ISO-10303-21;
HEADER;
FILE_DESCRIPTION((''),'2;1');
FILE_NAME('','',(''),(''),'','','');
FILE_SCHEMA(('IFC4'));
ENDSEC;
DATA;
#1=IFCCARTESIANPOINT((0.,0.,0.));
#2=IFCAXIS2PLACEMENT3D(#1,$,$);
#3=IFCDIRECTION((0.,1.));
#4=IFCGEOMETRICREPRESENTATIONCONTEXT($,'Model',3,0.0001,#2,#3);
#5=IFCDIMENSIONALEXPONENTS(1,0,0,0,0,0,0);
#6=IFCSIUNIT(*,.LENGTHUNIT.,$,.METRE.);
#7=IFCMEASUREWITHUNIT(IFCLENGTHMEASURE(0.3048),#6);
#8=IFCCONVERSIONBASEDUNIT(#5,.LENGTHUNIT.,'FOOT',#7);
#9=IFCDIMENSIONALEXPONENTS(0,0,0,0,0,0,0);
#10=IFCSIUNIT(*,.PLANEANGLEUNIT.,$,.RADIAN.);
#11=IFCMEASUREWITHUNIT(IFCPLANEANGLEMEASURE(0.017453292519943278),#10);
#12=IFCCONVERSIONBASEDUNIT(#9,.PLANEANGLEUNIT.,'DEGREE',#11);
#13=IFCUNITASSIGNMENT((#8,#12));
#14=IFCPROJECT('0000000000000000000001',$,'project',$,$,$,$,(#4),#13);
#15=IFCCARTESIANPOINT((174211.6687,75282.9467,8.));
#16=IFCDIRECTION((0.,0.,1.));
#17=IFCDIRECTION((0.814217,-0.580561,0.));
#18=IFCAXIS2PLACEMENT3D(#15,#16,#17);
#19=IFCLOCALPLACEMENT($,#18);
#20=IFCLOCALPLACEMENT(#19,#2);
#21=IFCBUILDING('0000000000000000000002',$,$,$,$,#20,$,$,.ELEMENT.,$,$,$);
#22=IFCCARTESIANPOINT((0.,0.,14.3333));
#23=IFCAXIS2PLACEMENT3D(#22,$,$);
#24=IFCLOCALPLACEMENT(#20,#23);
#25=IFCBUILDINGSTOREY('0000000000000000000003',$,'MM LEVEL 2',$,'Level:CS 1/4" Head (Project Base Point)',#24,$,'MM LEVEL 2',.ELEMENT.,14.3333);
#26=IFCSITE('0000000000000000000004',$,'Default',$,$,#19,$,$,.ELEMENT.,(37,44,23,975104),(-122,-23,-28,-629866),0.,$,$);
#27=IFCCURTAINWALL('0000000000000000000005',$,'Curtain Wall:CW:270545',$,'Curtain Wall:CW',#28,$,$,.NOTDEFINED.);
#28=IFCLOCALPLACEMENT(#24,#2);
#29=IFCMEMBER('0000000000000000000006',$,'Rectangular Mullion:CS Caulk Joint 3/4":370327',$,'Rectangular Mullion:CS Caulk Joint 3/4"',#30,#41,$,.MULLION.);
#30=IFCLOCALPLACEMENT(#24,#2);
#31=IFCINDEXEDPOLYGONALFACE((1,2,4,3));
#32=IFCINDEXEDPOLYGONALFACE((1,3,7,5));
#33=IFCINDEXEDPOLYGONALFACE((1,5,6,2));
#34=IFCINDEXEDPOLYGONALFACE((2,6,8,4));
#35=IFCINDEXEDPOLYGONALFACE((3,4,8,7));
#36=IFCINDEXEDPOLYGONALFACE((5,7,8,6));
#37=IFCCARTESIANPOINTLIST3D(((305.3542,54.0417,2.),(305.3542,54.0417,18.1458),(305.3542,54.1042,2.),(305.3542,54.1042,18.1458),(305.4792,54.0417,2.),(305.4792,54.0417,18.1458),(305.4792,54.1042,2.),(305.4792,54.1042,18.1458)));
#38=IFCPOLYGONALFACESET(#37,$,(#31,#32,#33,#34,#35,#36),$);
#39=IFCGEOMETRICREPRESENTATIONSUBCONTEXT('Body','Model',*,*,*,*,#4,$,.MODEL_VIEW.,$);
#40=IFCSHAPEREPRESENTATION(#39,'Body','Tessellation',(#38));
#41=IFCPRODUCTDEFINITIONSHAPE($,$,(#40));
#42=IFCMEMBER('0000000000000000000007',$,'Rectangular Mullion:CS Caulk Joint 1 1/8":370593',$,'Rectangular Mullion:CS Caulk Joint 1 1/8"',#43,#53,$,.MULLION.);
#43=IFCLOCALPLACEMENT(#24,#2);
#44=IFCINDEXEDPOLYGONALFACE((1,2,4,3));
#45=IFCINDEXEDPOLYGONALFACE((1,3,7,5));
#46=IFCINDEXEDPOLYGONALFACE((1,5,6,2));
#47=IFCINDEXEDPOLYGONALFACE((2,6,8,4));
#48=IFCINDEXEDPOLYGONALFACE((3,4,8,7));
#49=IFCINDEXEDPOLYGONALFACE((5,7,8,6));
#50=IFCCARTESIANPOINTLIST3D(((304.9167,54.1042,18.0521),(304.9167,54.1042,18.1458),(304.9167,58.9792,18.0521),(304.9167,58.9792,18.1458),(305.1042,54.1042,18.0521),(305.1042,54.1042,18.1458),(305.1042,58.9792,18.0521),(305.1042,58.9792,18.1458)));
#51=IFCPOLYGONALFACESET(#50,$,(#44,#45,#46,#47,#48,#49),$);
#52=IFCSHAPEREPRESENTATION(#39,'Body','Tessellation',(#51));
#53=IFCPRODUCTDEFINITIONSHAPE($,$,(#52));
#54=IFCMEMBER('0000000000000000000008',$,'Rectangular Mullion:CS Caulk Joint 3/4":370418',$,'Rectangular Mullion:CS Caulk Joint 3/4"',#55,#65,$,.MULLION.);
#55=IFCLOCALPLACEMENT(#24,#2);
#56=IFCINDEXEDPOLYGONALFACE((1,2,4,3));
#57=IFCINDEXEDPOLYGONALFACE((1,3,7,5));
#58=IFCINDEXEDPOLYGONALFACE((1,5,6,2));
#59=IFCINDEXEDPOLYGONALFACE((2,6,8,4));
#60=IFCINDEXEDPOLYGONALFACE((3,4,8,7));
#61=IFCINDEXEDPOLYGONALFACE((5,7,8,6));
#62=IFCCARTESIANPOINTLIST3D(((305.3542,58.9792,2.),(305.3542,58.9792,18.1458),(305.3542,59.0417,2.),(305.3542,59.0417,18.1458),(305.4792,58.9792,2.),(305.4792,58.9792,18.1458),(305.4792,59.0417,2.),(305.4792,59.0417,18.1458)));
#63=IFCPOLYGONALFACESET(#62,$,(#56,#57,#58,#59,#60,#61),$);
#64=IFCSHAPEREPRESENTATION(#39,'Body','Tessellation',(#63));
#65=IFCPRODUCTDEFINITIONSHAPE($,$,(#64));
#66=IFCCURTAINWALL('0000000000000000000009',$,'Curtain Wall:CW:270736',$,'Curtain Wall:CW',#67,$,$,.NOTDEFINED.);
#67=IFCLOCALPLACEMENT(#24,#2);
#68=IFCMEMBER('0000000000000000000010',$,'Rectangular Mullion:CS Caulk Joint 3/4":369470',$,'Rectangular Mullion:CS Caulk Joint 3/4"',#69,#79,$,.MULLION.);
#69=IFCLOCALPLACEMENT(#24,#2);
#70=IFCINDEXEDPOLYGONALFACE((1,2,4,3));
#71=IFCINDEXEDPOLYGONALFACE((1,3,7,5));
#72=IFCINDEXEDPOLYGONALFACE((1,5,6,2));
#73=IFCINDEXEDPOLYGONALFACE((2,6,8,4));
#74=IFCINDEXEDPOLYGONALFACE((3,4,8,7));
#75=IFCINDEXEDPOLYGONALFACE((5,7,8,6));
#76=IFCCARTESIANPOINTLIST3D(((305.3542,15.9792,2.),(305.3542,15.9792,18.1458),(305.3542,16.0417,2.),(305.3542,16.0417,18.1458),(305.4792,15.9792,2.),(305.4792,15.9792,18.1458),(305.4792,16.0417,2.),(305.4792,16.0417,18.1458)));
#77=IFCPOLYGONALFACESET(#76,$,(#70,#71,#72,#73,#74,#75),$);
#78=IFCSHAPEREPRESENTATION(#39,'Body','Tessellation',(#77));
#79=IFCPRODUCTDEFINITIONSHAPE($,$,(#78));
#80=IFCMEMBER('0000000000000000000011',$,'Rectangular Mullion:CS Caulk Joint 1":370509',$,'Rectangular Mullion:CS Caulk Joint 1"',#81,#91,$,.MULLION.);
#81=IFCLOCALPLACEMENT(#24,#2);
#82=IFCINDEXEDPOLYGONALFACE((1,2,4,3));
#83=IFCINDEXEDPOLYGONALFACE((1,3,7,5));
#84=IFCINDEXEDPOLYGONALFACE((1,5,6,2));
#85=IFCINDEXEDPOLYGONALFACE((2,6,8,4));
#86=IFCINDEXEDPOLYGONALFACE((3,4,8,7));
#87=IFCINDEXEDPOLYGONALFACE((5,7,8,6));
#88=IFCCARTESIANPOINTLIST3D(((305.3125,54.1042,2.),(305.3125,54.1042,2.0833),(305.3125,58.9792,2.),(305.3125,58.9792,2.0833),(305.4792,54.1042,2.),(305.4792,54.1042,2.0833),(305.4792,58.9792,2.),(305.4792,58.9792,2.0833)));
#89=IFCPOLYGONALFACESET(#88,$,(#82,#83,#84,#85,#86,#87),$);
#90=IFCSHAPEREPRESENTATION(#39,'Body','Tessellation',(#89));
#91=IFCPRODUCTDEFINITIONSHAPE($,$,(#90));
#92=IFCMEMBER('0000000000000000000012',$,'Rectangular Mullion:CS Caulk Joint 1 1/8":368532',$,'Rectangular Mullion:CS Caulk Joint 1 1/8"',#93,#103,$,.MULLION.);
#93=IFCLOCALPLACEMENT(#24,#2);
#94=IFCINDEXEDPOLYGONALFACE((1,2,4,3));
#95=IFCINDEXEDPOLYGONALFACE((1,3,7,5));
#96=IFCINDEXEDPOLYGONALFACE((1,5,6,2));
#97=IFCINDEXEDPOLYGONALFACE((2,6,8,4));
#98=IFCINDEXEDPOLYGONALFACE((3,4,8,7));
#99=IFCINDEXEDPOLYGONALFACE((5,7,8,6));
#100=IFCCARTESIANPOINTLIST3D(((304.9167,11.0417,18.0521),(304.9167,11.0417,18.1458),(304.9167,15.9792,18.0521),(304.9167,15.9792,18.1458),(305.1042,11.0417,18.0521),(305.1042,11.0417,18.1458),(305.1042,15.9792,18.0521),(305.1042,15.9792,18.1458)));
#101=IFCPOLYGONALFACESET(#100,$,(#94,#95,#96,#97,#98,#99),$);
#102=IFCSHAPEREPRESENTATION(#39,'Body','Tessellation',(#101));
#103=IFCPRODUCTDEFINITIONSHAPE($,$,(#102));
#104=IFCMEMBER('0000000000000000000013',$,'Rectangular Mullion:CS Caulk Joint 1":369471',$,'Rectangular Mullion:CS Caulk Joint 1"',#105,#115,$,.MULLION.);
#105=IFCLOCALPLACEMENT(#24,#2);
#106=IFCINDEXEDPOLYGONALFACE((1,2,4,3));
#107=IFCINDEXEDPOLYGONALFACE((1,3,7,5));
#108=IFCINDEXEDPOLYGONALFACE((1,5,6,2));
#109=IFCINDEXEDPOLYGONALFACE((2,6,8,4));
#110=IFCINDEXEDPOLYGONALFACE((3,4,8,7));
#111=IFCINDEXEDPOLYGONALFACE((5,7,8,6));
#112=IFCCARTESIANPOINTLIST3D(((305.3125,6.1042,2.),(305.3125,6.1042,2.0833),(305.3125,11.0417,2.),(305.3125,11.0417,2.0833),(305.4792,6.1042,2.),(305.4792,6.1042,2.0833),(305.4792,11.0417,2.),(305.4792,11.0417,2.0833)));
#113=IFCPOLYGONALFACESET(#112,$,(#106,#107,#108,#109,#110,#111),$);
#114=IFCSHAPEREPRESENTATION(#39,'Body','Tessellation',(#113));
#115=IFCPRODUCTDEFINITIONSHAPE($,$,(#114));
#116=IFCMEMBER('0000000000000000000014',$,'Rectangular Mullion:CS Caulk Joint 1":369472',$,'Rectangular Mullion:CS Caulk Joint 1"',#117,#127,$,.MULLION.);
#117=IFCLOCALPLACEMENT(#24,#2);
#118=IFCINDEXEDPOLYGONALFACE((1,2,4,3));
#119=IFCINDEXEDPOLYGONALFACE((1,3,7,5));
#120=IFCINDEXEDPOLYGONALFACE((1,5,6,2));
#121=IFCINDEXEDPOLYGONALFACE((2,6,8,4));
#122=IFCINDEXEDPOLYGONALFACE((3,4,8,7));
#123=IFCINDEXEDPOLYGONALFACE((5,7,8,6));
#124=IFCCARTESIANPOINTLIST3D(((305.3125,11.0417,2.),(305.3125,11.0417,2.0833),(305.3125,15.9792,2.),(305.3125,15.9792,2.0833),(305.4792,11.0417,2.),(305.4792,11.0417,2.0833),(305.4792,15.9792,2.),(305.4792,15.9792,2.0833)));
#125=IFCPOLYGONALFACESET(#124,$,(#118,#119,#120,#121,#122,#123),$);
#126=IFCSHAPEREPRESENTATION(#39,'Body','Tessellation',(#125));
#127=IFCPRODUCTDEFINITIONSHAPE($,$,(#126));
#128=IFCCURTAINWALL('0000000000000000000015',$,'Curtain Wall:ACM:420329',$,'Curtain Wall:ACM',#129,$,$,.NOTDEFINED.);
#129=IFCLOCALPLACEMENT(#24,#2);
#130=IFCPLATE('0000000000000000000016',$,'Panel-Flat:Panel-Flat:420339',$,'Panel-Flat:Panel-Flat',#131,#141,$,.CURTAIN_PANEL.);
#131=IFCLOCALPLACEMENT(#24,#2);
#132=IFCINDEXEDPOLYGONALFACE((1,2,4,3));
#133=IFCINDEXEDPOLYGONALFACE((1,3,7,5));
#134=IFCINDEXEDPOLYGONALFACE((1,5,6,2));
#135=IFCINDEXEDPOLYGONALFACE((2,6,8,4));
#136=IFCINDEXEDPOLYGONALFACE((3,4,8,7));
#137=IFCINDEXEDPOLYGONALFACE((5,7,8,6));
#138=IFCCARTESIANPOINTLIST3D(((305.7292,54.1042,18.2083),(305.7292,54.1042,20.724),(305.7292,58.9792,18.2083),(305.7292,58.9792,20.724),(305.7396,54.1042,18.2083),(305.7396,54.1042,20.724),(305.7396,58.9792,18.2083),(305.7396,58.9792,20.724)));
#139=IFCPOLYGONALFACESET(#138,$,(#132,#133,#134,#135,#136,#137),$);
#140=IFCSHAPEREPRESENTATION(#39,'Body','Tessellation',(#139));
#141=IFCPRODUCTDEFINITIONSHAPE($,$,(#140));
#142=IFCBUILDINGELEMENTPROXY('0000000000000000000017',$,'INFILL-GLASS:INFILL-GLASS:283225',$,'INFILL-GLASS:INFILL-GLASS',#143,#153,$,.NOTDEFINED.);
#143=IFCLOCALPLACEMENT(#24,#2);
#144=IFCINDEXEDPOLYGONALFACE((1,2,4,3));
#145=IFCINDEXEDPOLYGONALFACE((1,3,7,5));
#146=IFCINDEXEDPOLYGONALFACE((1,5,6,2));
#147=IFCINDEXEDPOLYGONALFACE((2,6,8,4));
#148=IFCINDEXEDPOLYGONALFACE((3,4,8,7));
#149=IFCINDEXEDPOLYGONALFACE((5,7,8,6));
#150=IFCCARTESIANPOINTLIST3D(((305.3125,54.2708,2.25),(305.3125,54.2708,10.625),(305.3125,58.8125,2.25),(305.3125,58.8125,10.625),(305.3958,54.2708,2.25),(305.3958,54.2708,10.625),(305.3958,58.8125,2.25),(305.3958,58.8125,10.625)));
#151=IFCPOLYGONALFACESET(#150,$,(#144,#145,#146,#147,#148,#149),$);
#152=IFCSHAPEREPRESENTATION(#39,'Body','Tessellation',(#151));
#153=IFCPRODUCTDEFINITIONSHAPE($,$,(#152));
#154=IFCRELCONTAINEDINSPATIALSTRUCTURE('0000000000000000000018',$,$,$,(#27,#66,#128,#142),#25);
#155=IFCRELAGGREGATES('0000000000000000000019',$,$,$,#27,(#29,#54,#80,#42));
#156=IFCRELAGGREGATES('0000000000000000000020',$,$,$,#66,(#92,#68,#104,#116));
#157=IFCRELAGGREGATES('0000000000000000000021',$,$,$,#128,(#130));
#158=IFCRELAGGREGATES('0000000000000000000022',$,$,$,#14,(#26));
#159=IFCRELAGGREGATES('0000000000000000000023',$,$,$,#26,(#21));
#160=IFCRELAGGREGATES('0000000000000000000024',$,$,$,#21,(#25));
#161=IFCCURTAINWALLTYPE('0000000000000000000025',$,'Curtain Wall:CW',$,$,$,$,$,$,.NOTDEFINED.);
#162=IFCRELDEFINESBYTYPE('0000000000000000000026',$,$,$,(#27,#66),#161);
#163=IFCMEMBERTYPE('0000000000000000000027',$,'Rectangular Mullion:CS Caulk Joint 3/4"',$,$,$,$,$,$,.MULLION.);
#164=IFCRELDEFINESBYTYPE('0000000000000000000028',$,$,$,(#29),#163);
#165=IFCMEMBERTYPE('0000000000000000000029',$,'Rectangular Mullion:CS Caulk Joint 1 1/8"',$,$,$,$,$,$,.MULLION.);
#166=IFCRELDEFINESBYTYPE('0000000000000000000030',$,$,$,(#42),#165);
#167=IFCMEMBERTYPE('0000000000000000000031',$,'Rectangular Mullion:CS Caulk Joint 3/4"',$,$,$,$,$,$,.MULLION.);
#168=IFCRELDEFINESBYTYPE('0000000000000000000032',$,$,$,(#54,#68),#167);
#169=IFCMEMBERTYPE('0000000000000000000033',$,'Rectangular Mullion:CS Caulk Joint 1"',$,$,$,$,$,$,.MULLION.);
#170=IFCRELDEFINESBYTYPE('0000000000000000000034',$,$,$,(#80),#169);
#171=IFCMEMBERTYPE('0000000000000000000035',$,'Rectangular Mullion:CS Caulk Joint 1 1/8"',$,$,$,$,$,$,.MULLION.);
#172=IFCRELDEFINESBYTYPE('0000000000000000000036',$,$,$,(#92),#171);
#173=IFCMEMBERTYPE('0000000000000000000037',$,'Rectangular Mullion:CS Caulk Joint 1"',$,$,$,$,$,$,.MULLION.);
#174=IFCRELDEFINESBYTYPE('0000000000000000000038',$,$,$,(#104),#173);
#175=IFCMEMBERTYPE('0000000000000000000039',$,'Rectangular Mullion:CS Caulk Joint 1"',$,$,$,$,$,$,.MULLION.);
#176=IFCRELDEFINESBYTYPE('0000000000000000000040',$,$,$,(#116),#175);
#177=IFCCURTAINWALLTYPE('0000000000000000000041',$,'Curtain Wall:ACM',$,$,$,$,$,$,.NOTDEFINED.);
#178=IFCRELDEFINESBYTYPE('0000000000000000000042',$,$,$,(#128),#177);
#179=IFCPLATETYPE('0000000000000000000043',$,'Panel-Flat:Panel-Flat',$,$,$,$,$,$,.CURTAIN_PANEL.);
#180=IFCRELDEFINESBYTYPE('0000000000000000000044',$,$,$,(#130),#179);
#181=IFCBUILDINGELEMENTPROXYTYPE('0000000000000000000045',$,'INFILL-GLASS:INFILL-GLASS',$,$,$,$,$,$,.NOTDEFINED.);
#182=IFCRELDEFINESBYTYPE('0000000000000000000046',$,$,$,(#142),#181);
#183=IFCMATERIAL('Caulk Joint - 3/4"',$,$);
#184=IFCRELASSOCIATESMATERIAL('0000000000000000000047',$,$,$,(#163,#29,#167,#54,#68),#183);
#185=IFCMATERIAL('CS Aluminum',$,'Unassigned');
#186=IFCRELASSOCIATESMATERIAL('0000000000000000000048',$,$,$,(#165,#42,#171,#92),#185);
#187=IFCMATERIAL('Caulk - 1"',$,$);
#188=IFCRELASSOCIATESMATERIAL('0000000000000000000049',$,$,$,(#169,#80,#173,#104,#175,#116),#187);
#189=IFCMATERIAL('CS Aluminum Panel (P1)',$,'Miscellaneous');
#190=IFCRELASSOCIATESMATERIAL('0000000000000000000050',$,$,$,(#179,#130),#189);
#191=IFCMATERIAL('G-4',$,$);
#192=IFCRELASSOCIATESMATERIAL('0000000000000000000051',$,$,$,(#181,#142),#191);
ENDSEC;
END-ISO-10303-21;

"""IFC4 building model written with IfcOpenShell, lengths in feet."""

from ifc_helpers import new_model, entity, si_unit, converted_unit, direction, frame, origin, place, context, subcontext, project, spatial, indexed_curve, outline, extrude, source, transform, mapped, material, type_object, type_shapes, element, aggregate, save


model = new_model("IFC4")

# Units and contexts
model_context = context("Model", 3, precision=0.0001, world=origin(), true_north=direction((0.0, 1.0)))
body_context = subcontext(model_context, "Body", "Model", "MODEL_VIEW")
ifc_project = project(units=[converted_unit("LENGTHUNIT", "FOOT", entity("IfcLengthMeasure", 0.3048), si_unit("LENGTHUNIT", "METRE"), dimensions=[1, 0, 0, 0, 0, 0, 0]), converted_unit("PLANEANGLEUNIT", "DEGREE", entity("IfcPlaneAngleMeasure", 0.017453292519943278), si_unit("PLANEANGLEUNIT", "RADIAN"), dimensions=[0, 0, 0, 0, 0, 0, 0])], contexts=[model_context])

# Site, building, storey
site_placement = place(None, frame((174211.6687, 75282.9467, 8.0), z_axis=(0.0, 0.0, 1.0), x_axis=(0.814217, -0.580561, 0.0)))
site = spatial("IfcSite", under=ifc_project, at=site_placement, Name="Default", CompositionType="ELEMENT", RefLatitude=(37, 44, 23, 975104), RefLongitude=(-122, -23, -28, -629866), RefElevation=0.0)
building_placement = place(site_placement, origin())
building = spatial("IfcBuilding", under=site, at=building_placement, CompositionType="ELEMENT")
storey_placement = place(building_placement, frame((0.0, 0.0, 14.3333)))
storey = spatial("IfcBuildingStorey", under=building, at=storey_placement, Name="MM LEVEL 2", ObjectType="Level:CS 1/4\" Head (Project Base Point)", LongName="MM LEVEL 2", CompositionType="ELEMENT", Elevation=14.3333)

# Curtain wall, members
curtain_wall_type_1 = type_object("IfcCurtainWallType", Name="Curtain Wall:CW", PredefinedType="NOTDEFINED")
curtain_wall_1_placement = place(storey_placement, frame((0.0, 0.0, -14.3333)))
curtain_wall_1 = element("IfcCurtainWall", 1, at=curtain_wall_1_placement, inside=storey, type_object=curtain_wall_type_1, Name="Curtain Wall:CW:270545", ObjectType="Curtain Wall:CW", PredefinedType="NOTDEFINED")
ifc_material_1 = material(Name="Caulk Joint - 3/4\"")
member_type_1 = type_object("IfcMemberType", Name="Rectangular Mullion:CS Caulk Joint 3/4\"", PredefinedType="MULLION", material=ifc_material_1)
shared_shape_1 = source(origin(), body_context, "Body", "SweptSolid", [
    extrude(outline(indexed_curve([(-0.0625, -0.0312), (0.0625, -0.0312), (0.0625, 0.0312), (-0.0625, 0.0312), (-0.0625, -0.0312)], self_intersect=False)), frame((-0.0312, 0.0625, -16.1458), z_axis=(0.0, 0.0, 1.0), x_axis=(0.0, -1.0, 0.0)), (0.0, 0.0, 1.0), 16.1458),
])
type_shapes(member_type_1, [shared_shape_1])
member_1_placement = place(curtain_wall_1_placement, frame((305.4792, 54.0417, 16.3333), z_axis=(0.0, 0.0, -1.0), x_axis=(0.0, -1.0, 0.0)))
member_1 = element("IfcMember", 2, at=member_1_placement, type_object=member_type_1, material=ifc_material_1, Name="Rectangular Mullion:CS Caulk Joint 3/4\":370327", ObjectType="Rectangular Mullion:CS Caulk Joint 3/4\"", PredefinedType="MULLION", context=body_context, shape_type="MappedRepresentation", body=[
    mapped(shared_shape_1, transform((0.0, 0.0, 0.0), scale=1.0)),
])
ifc_material_2 = material(Name="CS Aluminum", Category="Unassigned")
member_type_2 = type_object("IfcMemberType", Name="Rectangular Mullion:CS Caulk Joint 1 1/8\"", PredefinedType="MULLION", material=ifc_material_2)
shared_shape_2 = source(origin(), body_context, "Body", "SweptSolid", [
    extrude(outline(indexed_curve([(-0.0937, -0.0469), (0.0938, -0.0469), (0.0938, 0.0469), (-0.0937, 0.0469), (-0.0937, -0.0469)], self_intersect=False)), frame((-0.0469, 0.4688, -4.875), z_axis=(0.0, 0.0, 1.0), x_axis=(0.0, -1.0, 0.0)), (0.0, 0.0, 1.0), 4.875),
])
type_shapes(member_type_2, [shared_shape_2])
member_2_placement = place(curtain_wall_1_placement, frame((305.4792, 54.1042, 32.4792), z_axis=(0.0, -1.0, 0.0), x_axis=(0.0, 0.0, 1.0)))
member_2 = element("IfcMember", 3, at=member_2_placement, type_object=member_type_2, material=ifc_material_2, Name="Rectangular Mullion:CS Caulk Joint 1 1/8\":370593", ObjectType="Rectangular Mullion:CS Caulk Joint 1 1/8\"", PredefinedType="MULLION", context=body_context, shape_type="MappedRepresentation", body=[
    mapped(shared_shape_2, transform((0.0, 0.0, 0.0), scale=1.0)),
])
member_type_3 = type_object("IfcMemberType", Name="Rectangular Mullion:CS Caulk Joint 3/4\"", PredefinedType="MULLION", material=ifc_material_1)
shared_shape_3 = source(origin(), body_context, "Body", "SweptSolid", [
    extrude(outline(indexed_curve([(-0.0312, -0.0625), (0.0312, -0.0625), (0.0312, 0.0625), (-0.0312, 0.0625), (-0.0312, -0.0625)], self_intersect=False)), frame((-0.0312, 0.0625, -16.1458), z_axis=(0.0, 0.0, 1.0), x_axis=(-1.0, 0.0, 0.0)), (0.0, 0.0, 1.0), 16.1458),
])
type_shapes(member_type_3, [shared_shape_3])
member_3_placement = place(curtain_wall_1_placement, frame((305.4792, 59.0417, 32.4792), z_axis=(0.0, 0.0, 1.0), x_axis=(0.0, 1.0, 0.0)))
member_3 = element("IfcMember", 4, at=member_3_placement, type_object=member_type_3, material=ifc_material_1, Name="Rectangular Mullion:CS Caulk Joint 3/4\":370418", ObjectType="Rectangular Mullion:CS Caulk Joint 3/4\"", PredefinedType="MULLION", context=body_context, shape_type="MappedRepresentation", body=[
    mapped(shared_shape_3, transform((0.0, 0.0, 0.0), scale=1.0)),
])

# Curtain wall, member
curtain_wall_2_placement = place(storey_placement, frame((0.0, 0.0, -14.3333)))
curtain_wall_2 = element("IfcCurtainWall", 5, at=curtain_wall_2_placement, inside=storey, type_object=curtain_wall_type_1, Name="Curtain Wall:CW:270736", ObjectType="Curtain Wall:CW", PredefinedType="NOTDEFINED")
member_4_placement = place(curtain_wall_2_placement, frame((305.4792, 16.0417, 32.4792), z_axis=(0.0, 0.0, 1.0), x_axis=(0.0, 1.0, 0.0)))
member_4 = element("IfcMember", 6, at=member_4_placement, type_object=member_type_3, material=ifc_material_1, Name="Rectangular Mullion:CS Caulk Joint 3/4\":369470", ObjectType="Rectangular Mullion:CS Caulk Joint 3/4\"", PredefinedType="MULLION", context=body_context, shape_type="MappedRepresentation", body=[
    mapped(shared_shape_3, transform((0.0, 0.0, 0.0), scale=1.0)),
])

# Members
ifc_material_3 = material(Name="Caulk - 1\"")
member_type_4 = type_object("IfcMemberType", Name="Rectangular Mullion:CS Caulk Joint 1\"", PredefinedType="MULLION", material=ifc_material_3)
shared_shape_4 = source(origin(), body_context, "Body", "SweptSolid", [
    extrude(outline(indexed_curve([(-0.0417, -0.0833), (0.0417, -0.0833), (0.0417, 0.0833), (-0.0417, 0.0833), (-0.0417, -0.0833)], self_intersect=False)), frame((-0.0417, 0.0833, -4.875), z_axis=(0.0, 0.0, 1.0), x_axis=(-1.0, 0.0, 0.0)), (0.0, 0.0, 1.0), 4.875),
])
type_shapes(member_type_4, [shared_shape_4])
member_5_placement = place(curtain_wall_1_placement, frame((305.4792, 58.9792, 16.3333), z_axis=(0.0, 1.0, 0.0), x_axis=(0.0, 0.0, -1.0)))
member_5 = element("IfcMember", 7, at=member_5_placement, type_object=member_type_4, material=ifc_material_3, Name="Rectangular Mullion:CS Caulk Joint 1\":370509", ObjectType="Rectangular Mullion:CS Caulk Joint 1\"", PredefinedType="MULLION", context=body_context, shape_type="MappedRepresentation", body=[
    mapped(shared_shape_4, transform((0.0, 0.0, 0.0), scale=1.0)),
])
aggregate(curtain_wall_1, [member_1, member_3, member_5, member_2])
member_type_5 = type_object("IfcMemberType", Name="Rectangular Mullion:CS Caulk Joint 1 1/8\"", PredefinedType="MULLION", material=ifc_material_2)
shared_shape_5 = source(origin(), body_context, "Body", "SweptSolid", [
    extrude(outline(indexed_curve([(-0.0937, -0.0469), (0.0938, -0.0469), (0.0938, 0.0469), (-0.0937, 0.0469), (-0.0937, -0.0469)], self_intersect=False)), frame((-0.0469, 0.4688, -4.9375), z_axis=(0.0, 0.0, 1.0), x_axis=(0.0, -1.0, 0.0)), (0.0, 0.0, 1.0), 4.9375),
])
type_shapes(member_type_5, [shared_shape_5])
member_6_placement = place(curtain_wall_2_placement, frame((305.4792, 11.0417, 32.4792), z_axis=(0.0, -1.0, 0.0), x_axis=(0.0, 0.0, 1.0)))
member_6 = element("IfcMember", 8, at=member_6_placement, type_object=member_type_5, material=ifc_material_2, Name="Rectangular Mullion:CS Caulk Joint 1 1/8\":368532", ObjectType="Rectangular Mullion:CS Caulk Joint 1 1/8\"", PredefinedType="MULLION", context=body_context, shape_type="MappedRepresentation", body=[
    mapped(shared_shape_5, transform((0.0, 0.0, 0.0), scale=1.0)),
])
member_type_6 = type_object("IfcMemberType", Name="Rectangular Mullion:CS Caulk Joint 1\"", PredefinedType="MULLION", material=ifc_material_3)
shared_shape_6 = source(origin(), body_context, "Body", "SweptSolid", [
    extrude(outline(indexed_curve([(-0.0417, -0.0833), (0.0417, -0.0833), (0.0417, 0.0833), (-0.0417, 0.0833), (-0.0417, -0.0833)], self_intersect=False)), frame((-0.0417, 0.0833, -4.9375), z_axis=(0.0, 0.0, 1.0), x_axis=(-1.0, 0.0, 0.0)), (0.0, 0.0, 1.0), 4.9375),
])
type_shapes(member_type_6, [shared_shape_6])
member_7_placement = place(curtain_wall_2_placement, frame((305.4792, 11.0417, 16.3333), z_axis=(0.0, 1.0, 0.0), x_axis=(0.0, 0.0, -1.0)))
member_7 = element("IfcMember", 9, at=member_7_placement, type_object=member_type_6, material=ifc_material_3, Name="Rectangular Mullion:CS Caulk Joint 1\":369471", ObjectType="Rectangular Mullion:CS Caulk Joint 1\"", PredefinedType="MULLION", context=body_context, shape_type="MappedRepresentation", body=[
    mapped(shared_shape_6, transform((0.0, 0.0, 0.0), scale=1.0)),
])
member_type_7 = type_object("IfcMemberType", Name="Rectangular Mullion:CS Caulk Joint 1\"", PredefinedType="MULLION", material=ifc_material_3)
shared_shape_7 = source(origin(), body_context, "Body", "SweptSolid", [
    extrude(outline(indexed_curve([(-0.0417, -0.0833), (0.0417, -0.0833), (0.0417, 0.0833), (-0.0417, 0.0833), (-0.0417, -0.0833)], self_intersect=False)), frame((-0.0417, 0.0833, -4.9375), z_axis=(0.0, 0.0, 1.0), x_axis=(-1.0, 0.0, 0.0)), (0.0, 0.0, 1.0), 4.9375),
])
type_shapes(member_type_7, [shared_shape_7])
member_8_placement = place(curtain_wall_2_placement, frame((305.4792, 15.9792, 16.3333), z_axis=(0.0, 1.0, 0.0), x_axis=(0.0, 0.0, -1.0)))
member_8 = element("IfcMember", 10, at=member_8_placement, type_object=member_type_7, material=ifc_material_3, Name="Rectangular Mullion:CS Caulk Joint 1\":369472", ObjectType="Rectangular Mullion:CS Caulk Joint 1\"", PredefinedType="MULLION", context=body_context, shape_type="MappedRepresentation", body=[
    mapped(shared_shape_7, transform((0.0, 0.0, 0.0), scale=1.0)),
])
aggregate(curtain_wall_2, [member_6, member_4, member_7, member_8])

# Curtain wall, plate
curtain_wall_type_2 = type_object("IfcCurtainWallType", Name="Curtain Wall:ACM", PredefinedType="NOTDEFINED")
curtain_wall_3_placement = place(storey_placement, frame((0.0, 0.0, -14.3333)))
curtain_wall_3 = element("IfcCurtainWall", 11, at=curtain_wall_3_placement, inside=storey, type_object=curtain_wall_type_2, Name="Curtain Wall:ACM:420329", ObjectType="Curtain Wall:ACM", PredefinedType="NOTDEFINED")
ifc_material_4 = material(Name="CS Aluminum Panel (P1)", Category="Miscellaneous")
plate_type = type_object("IfcPlateType", Name="Panel-Flat:Panel-Flat", PredefinedType="CURTAIN_PANEL", material=ifc_material_4)
shared_shape_8 = source(origin(), body_context, "Body", "SweptSolid", [
    extrude(outline(indexed_curve([(-0.0052, -2.4375), (0.0052, -2.4375), (0.0052, 2.4375), (-0.0052, 2.4375), (-0.0052, -2.4375)], self_intersect=False)), frame((0.0, -0.0052, 0.0), z_axis=(0.0, 0.0, 1.0), x_axis=(0.0, -1.0, 0.0)), (0.0, 0.0, 1.0), 2.5156),
])
type_shapes(plate_type, [shared_shape_8])
plate_placement = place(curtain_wall_3_placement, frame((305.7396, 56.5417, 32.5417), z_axis=(0.0, 0.0, 1.0), x_axis=(0.0, -1.0, 0.0)))
plate = element("IfcPlate", 12, at=plate_placement, type_object=plate_type, material=ifc_material_4, Name="Panel-Flat:Panel-Flat:420339", ObjectType="Panel-Flat:Panel-Flat", PredefinedType="CURTAIN_PANEL", context=body_context, shape_type="MappedRepresentation", body=[
    mapped(shared_shape_8, transform((0.0, 0.0, 0.0), scale=1.0)),
])
aggregate(curtain_wall_3, [plate])

# Building element proxy
ifc_material_5 = material(Name="G-4")
building_element_proxy_type_1 = type_object("IfcBuildingElementProxyType", Name="INFILL-GLASS:INFILL-GLASS", PredefinedType="NOTDEFINED", material=ifc_material_5)
shared_shape_9 = source(origin(), body_context, "Body", "SweptSolid", [
    extrude(outline(indexed_curve([(-0.0417, -2.2708), (0.0417, -2.2708), (0.0417, 2.2708), (-0.0417, 2.2708), (-0.0417, -2.2708)], self_intersect=False)), frame((0.0, 0.125, 0.1667), z_axis=(0.0, 0.0, 1.0), x_axis=(0.0, 1.0, 0.0)), (0.0, 0.0, 1.0), 8.375),
])
type_shapes(building_element_proxy_type_1, [shared_shape_9])
proxy_1_placement = place(storey_placement, frame((305.4792, 56.5417, 2.0833), z_axis=(0.0, 0.0, 1.0), x_axis=(0.0, 1.0, 0.0)))
element("IfcBuildingElementProxy", 13, at=proxy_1_placement, inside=storey, type_object=building_element_proxy_type_1, material=ifc_material_5, Name="INFILL-GLASS:INFILL-GLASS:283225", ObjectType="INFILL-GLASS:INFILL-GLASS", PredefinedType="NOTDEFINED", context=body_context, shape_type="MappedRepresentation", body=[
    mapped(shared_shape_9, transform((0.0, 0.0, 0.0), scale=1.0)),
])

save(model, "model.ifc")
